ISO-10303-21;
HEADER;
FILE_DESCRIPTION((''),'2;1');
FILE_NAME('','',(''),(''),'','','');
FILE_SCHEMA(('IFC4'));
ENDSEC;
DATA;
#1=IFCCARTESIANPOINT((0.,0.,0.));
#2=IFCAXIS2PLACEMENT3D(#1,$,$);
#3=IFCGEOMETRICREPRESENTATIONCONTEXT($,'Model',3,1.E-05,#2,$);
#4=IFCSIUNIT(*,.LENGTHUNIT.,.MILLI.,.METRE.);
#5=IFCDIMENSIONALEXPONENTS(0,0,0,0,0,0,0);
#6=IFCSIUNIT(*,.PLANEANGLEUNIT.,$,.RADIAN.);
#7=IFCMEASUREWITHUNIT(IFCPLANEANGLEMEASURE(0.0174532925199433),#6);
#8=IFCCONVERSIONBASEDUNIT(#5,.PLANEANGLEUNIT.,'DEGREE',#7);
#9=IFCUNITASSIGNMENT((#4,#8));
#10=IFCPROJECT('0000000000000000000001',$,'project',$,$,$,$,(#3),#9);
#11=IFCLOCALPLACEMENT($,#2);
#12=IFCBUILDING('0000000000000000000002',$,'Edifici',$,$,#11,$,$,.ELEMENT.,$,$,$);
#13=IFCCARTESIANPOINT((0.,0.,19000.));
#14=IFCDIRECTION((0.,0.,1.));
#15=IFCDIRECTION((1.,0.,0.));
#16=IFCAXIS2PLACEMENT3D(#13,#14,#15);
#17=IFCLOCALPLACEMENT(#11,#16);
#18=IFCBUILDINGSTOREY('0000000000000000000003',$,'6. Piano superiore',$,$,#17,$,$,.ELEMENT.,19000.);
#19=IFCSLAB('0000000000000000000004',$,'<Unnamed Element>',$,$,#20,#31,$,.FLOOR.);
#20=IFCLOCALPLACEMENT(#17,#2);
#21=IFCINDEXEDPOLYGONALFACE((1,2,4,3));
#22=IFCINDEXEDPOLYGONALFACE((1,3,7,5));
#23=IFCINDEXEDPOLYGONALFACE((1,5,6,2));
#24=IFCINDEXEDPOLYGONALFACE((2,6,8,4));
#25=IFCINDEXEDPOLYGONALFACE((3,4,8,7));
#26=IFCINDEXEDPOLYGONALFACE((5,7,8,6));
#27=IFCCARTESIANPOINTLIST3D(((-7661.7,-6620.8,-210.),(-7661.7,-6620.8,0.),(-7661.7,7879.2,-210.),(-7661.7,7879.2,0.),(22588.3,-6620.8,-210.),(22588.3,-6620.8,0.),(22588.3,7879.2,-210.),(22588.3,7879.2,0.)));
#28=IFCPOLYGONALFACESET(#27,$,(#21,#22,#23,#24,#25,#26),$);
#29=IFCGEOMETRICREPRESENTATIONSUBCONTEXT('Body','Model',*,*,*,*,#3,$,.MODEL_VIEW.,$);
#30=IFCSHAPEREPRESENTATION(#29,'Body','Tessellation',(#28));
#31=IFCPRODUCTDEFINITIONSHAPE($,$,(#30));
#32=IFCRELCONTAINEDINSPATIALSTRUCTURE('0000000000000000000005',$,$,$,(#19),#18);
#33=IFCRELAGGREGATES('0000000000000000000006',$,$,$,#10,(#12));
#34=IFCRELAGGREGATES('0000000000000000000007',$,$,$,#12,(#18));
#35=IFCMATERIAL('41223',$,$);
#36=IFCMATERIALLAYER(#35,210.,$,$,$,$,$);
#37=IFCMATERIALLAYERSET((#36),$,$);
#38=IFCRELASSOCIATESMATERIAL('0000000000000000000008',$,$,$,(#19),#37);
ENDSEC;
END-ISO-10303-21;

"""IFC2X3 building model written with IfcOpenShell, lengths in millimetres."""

from ifc_helpers import new_model, entity, si_unit, converted_unit, frame, frame_2d, origin, origin_with_axes, place, context, subcontext, project, spatial, rectangle, extrude, material, layer, layer_set, layer_usage, element, save


model = new_model("IFC2X3")

# Units and contexts
model_context = context("Model", 3, precision=1e-05, world=origin())
body_context = subcontext(model_context, "Body", "Model", "MODEL_VIEW")
ifc_project = project(units=[si_unit("LENGTHUNIT", "METRE", prefix="MILLI"), converted_unit("PLANEANGLEUNIT", "DEGREE", entity("IfcPlaneAngleMeasure", 0.0174532925199433), si_unit("PLANEANGLEUNIT", "RADIAN"), dimensions=[0, 0, 0, 0, 0, 0, 0])], contexts=[model_context])

# Building, storey
building_placement = place(None, origin())
building = spatial("IfcBuilding", under=ifc_project, at=building_placement, Name="Edifici", CompositionType="ELEMENT")
storey_placement = place(building_placement, frame((0.0, 0.0, 19000.0), z_axis=(0.0, 0.0, 1.0), x_axis=(1.0, 0.0, 0.0)))
storey = spatial("IfcBuildingStorey", under=building, at=storey_placement, Name="6. Piano superiore", CompositionType="ELEMENT", Elevation=19000.0)

# Slab
ifc_material = material(Name="41223")
ifc_layer = layer(ifc_material, 210.0)
ifc_layer_set = layer_set([ifc_layer])
ifc_layer_usage = layer_usage(ifc_layer_set, "AXIS3", "POSITIVE", 0.0)
slab_placement = place(storey_placement, frame((-7661.7, -6620.8, -210.0), z_axis=(0.0, 0.0, 1.0), x_axis=(1.0, 0.0, 0.0)))
element("IfcSlab", 1, at=slab_placement, inside=storey, material=ifc_layer_usage, Name="<Unnamed Element>", PredefinedType="FLOOR", context=body_context, shape_type="SweptSolid", body=[
    extrude(rectangle(XDim=30250.0, YDim=14500.0, at=frame_2d((15125.0, 7250.0), x_axis=(1.0, 0.0))), origin_with_axes(), (0.0, 0.0, 1.0), 210.0),
])

save(model, "model.ifc")
